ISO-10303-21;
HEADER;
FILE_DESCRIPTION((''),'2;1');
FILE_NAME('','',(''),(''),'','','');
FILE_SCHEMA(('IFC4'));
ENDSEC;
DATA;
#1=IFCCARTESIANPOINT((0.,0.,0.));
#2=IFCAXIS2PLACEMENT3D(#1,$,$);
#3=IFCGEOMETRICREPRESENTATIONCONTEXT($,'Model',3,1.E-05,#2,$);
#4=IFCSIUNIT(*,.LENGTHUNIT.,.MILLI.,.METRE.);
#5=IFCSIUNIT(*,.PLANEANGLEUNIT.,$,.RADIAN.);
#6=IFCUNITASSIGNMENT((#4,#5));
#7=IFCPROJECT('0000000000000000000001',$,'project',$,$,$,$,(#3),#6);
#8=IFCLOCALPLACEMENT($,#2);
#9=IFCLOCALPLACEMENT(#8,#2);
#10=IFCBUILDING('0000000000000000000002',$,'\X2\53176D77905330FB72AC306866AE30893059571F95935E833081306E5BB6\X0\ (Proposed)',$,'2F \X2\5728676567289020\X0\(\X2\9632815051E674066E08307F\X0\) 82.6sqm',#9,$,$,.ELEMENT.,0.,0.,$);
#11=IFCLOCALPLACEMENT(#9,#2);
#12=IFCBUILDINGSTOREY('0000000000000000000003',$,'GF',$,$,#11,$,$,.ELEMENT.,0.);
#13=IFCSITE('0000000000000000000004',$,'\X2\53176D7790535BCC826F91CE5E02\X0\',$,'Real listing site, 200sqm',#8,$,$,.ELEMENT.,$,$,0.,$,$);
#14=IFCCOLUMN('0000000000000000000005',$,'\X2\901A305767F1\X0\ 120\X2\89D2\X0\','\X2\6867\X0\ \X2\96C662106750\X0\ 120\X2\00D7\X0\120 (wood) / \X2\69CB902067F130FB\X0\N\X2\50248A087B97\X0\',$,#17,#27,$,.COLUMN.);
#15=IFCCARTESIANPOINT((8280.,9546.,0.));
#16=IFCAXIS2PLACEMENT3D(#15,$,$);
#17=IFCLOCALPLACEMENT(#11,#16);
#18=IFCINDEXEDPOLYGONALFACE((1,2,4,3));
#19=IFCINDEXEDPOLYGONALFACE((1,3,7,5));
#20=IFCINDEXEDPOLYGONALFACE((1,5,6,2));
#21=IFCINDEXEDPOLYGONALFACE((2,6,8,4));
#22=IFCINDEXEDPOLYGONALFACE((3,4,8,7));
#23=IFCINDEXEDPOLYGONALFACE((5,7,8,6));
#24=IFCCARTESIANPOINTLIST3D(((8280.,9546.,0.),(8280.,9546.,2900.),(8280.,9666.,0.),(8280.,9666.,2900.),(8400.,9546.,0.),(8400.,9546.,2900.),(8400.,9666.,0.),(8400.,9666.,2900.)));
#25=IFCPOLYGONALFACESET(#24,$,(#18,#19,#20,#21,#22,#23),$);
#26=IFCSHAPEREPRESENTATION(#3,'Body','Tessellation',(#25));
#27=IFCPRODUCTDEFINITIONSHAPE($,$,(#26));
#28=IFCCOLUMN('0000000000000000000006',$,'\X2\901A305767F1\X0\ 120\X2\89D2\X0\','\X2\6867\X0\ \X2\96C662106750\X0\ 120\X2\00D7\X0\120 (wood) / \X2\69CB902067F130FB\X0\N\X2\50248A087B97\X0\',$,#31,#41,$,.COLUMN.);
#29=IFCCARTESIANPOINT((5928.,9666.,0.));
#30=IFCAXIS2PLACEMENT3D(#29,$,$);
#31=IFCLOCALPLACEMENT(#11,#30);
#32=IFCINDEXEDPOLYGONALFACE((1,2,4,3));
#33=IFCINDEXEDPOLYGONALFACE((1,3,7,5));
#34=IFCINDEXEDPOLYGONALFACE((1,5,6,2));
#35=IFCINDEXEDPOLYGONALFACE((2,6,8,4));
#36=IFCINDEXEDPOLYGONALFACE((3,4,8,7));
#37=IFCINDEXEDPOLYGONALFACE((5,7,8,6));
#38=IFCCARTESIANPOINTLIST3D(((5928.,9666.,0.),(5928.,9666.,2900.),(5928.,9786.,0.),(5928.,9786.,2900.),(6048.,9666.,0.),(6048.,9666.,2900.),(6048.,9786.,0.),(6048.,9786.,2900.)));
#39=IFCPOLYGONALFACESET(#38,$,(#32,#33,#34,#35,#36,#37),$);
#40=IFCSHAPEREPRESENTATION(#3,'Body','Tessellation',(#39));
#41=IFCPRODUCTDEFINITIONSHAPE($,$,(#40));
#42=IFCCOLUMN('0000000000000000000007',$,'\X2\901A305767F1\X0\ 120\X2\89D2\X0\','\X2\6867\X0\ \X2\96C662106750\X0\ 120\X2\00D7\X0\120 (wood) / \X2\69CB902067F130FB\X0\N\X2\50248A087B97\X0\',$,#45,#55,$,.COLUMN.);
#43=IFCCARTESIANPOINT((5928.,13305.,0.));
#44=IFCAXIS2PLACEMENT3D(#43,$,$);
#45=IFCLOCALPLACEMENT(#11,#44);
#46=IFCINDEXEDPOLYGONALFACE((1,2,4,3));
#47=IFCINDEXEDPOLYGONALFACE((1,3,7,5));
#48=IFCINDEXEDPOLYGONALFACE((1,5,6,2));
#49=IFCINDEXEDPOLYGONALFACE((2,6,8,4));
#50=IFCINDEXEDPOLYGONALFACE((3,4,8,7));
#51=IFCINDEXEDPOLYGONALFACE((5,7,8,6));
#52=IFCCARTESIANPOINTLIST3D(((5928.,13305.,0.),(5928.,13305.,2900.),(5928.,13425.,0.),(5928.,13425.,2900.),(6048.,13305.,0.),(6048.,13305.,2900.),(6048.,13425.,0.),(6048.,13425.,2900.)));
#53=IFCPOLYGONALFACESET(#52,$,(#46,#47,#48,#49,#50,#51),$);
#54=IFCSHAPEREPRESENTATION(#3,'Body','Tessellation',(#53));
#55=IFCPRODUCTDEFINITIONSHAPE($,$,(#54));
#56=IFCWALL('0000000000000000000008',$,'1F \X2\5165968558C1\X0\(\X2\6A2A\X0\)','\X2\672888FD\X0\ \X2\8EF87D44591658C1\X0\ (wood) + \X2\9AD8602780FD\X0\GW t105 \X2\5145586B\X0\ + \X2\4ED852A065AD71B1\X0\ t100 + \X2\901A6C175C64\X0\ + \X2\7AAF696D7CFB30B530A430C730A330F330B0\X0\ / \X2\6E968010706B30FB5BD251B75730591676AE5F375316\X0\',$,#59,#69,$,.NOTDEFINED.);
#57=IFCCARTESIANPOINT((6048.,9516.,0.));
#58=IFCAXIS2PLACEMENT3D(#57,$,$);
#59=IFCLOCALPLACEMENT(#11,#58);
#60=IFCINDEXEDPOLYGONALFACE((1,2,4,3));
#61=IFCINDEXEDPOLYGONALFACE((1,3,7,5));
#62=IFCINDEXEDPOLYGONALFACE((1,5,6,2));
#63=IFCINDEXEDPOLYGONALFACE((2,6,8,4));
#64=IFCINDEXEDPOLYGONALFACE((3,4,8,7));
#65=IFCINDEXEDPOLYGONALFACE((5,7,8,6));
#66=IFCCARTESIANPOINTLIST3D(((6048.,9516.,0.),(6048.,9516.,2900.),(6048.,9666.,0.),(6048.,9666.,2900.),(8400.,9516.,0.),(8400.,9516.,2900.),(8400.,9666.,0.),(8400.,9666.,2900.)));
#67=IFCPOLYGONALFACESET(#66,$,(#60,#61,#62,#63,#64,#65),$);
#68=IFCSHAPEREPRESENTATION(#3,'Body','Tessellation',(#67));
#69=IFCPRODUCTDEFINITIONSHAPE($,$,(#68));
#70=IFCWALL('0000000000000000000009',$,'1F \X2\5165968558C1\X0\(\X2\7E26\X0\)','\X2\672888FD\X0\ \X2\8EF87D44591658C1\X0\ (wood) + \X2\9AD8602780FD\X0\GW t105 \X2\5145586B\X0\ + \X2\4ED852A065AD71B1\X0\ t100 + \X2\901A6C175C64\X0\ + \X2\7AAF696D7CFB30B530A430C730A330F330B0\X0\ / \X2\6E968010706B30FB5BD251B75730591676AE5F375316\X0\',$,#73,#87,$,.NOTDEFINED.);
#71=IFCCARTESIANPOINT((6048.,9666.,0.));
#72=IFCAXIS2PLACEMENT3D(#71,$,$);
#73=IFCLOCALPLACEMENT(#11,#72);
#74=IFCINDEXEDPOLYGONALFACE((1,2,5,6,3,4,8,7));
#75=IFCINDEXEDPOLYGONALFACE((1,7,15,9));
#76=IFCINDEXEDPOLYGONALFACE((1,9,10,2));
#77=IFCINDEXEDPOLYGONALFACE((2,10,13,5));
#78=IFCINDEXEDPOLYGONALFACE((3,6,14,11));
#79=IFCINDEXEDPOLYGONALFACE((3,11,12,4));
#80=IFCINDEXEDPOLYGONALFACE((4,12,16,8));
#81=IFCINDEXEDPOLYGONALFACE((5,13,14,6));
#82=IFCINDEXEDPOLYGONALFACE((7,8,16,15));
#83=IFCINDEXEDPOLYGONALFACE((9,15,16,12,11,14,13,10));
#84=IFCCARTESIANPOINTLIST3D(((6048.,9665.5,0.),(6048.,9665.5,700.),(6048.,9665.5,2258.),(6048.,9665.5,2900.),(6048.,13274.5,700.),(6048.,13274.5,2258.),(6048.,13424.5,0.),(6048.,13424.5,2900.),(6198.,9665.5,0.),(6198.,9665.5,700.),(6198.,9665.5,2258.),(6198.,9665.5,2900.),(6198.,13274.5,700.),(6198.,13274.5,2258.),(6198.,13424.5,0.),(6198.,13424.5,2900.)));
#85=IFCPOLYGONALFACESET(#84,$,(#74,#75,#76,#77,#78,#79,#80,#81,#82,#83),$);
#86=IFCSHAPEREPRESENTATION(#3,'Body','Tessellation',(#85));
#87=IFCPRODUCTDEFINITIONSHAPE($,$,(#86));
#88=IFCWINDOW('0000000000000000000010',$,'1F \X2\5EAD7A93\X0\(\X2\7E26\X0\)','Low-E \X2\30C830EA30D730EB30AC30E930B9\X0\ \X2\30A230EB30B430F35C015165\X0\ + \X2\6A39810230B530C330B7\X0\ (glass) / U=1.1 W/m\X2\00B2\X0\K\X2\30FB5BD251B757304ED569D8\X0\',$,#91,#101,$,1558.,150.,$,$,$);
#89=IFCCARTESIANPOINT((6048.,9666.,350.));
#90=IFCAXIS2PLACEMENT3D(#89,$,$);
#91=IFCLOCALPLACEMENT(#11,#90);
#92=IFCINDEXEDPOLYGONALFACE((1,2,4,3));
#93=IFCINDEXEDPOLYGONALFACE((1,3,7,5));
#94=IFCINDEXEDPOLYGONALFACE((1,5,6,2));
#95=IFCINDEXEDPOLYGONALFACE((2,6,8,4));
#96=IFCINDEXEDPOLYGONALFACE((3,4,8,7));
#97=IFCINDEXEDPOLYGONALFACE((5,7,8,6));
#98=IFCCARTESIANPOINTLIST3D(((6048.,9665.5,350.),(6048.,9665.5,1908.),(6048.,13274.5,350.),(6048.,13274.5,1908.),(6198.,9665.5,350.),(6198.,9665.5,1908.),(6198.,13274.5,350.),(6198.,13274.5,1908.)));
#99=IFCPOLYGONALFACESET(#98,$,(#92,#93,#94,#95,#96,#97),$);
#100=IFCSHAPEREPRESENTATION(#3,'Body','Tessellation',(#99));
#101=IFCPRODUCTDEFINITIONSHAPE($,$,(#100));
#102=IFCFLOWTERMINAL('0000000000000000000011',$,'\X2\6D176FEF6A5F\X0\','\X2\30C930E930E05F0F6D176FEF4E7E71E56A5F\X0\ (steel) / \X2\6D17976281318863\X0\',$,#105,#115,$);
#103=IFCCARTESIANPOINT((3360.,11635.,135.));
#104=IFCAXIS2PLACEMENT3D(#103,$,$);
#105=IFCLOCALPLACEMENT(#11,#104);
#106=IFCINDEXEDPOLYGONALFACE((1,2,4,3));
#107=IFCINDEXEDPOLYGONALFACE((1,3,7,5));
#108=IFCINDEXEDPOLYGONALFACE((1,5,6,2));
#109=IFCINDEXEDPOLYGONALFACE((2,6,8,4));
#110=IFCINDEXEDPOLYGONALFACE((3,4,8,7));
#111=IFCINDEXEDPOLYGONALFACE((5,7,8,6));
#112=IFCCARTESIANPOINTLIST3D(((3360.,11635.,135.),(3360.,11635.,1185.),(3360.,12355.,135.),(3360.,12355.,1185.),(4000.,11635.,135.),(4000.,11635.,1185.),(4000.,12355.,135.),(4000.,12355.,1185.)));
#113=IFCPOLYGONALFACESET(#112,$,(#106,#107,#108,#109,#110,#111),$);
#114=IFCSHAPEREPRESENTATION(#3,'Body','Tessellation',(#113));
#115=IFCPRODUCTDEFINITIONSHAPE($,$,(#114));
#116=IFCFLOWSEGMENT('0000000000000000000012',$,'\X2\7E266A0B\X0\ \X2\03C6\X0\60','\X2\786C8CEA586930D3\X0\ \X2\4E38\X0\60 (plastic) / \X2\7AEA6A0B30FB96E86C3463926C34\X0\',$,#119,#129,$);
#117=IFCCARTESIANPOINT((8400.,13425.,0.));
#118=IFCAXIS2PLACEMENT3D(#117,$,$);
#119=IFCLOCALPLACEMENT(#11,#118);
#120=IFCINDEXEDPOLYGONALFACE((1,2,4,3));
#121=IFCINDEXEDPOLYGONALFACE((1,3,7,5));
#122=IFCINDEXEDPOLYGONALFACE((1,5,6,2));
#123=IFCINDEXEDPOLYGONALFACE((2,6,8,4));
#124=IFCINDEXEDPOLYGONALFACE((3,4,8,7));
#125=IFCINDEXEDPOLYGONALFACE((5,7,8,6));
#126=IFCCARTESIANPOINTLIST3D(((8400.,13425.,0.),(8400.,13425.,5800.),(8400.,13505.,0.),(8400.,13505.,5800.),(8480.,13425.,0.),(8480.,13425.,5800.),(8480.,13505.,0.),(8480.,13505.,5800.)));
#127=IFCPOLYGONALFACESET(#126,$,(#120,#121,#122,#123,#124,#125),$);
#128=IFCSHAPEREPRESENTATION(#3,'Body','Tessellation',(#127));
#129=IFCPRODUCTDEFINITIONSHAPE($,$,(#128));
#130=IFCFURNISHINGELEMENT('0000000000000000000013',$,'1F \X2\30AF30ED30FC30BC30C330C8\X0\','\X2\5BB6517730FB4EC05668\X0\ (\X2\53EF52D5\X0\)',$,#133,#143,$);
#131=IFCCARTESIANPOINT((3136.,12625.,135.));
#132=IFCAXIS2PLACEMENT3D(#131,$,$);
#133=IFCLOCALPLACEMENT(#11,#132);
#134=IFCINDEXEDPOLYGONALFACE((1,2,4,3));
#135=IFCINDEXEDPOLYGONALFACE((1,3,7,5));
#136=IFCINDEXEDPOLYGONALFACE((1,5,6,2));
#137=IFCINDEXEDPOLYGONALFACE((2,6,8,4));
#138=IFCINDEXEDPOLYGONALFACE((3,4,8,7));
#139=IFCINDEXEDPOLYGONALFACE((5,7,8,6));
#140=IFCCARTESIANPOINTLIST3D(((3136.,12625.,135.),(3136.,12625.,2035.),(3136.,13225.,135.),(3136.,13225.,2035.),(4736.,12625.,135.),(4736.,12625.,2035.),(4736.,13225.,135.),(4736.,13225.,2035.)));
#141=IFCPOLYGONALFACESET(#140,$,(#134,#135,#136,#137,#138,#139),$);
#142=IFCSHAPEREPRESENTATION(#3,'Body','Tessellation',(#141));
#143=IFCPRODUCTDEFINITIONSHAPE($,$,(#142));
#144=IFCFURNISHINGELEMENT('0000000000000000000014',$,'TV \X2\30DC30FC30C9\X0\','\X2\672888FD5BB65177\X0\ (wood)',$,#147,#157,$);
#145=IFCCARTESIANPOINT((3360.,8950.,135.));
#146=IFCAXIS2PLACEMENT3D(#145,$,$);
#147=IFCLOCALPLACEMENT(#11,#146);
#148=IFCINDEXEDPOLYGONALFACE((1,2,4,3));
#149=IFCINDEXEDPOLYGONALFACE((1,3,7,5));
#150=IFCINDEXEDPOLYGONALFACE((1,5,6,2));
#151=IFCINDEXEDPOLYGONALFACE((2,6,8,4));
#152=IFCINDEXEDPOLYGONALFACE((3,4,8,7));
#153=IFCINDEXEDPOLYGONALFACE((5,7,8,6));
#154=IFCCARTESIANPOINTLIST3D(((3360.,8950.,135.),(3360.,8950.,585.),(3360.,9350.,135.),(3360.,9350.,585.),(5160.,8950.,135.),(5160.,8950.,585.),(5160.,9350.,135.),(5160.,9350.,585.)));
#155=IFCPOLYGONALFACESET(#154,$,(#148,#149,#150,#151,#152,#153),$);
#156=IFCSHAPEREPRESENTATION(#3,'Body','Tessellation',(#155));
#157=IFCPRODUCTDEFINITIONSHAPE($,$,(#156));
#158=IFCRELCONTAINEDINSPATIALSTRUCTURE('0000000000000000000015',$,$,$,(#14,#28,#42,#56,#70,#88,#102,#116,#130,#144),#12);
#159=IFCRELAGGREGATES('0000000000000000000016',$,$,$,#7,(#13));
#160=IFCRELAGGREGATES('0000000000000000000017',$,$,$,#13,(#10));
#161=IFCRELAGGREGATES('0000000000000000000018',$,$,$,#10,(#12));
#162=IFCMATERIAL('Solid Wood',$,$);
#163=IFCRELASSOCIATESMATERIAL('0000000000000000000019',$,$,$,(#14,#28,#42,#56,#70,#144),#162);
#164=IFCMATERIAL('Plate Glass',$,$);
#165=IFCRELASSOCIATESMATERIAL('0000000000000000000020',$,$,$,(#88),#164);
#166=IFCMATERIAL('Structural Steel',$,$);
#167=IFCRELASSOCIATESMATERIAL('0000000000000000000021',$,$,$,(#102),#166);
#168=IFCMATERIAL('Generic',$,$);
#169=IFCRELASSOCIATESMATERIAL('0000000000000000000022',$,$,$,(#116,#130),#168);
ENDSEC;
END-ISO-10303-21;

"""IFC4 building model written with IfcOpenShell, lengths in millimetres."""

from ifc_helpers import new_model, si_unit, frame, frame_2d, origin, place, context, project, spatial, rectangle, extrude, material, element, fill, save


model = new_model("IFC4")

# Units and contexts
model_context = context("Model", 3, precision=1e-05, world=origin())
ifc_project = project(units=[si_unit("LENGTHUNIT", "METRE", prefix="MILLI"), si_unit("PLANEANGLEUNIT", "RADIAN")], contexts=[model_context])

# Site, building, storey
site_placement = place(None, origin())
site = spatial("IfcSite", under=ifc_project, at=site_placement, Name="北海道富良野市", ObjectType="Real listing site, 200sqm", CompositionType="ELEMENT", RefElevation=0.0)
building_placement = place(site_placement, origin())
building = spatial("IfcBuilding", under=site, at=building_placement, Name="北海道・犬と暮らす土間広めの家 (Proposed)", ObjectType="2F 在来木造(防腐処理済み) 82.6sqm", CompositionType="ELEMENT", ElevationOfRefHeight=0.0, ElevationOfTerrain=0.0)
storey_placement = place(building_placement, origin())
storey = spatial("IfcBuildingStorey", under=building, at=storey_placement, Name="GF", CompositionType="ELEMENT", Elevation=0.0)

# Columns
ifc_material_1 = material(Name="Solid Wood")
column_1_placement = place(storey_placement, frame((8280.0, 9546.0, 0.0)))
element("IfcColumn", 1, at=column_1_placement, inside=storey, material=ifc_material_1, Name="通し柱 120角", Description="桧 集成材 120×120 (wood) / 構造柱・N値計算", PredefinedType="COLUMN", context=model_context, shape_type="SweptSolid", body=[
    extrude(rectangle(XDim=120.0, YDim=120.0, at=frame_2d((60.0, 60.0))), frame((8280.0, 9546.0, 0.0)), (0.0, 0.0, 1.0), 2900.0),
])
column_2_placement = place(storey_placement, frame((5928.0, 9666.0, 0.0)))
element("IfcColumn", 2, at=column_2_placement, inside=storey, material=ifc_material_1, Name="通し柱 120角", Description="桧 集成材 120×120 (wood) / 構造柱・N値計算", PredefinedType="COLUMN", context=model_context, shape_type="SweptSolid", body=[
    extrude(rectangle(XDim=120.0, YDim=120.0, at=frame_2d((60.0, 60.0))), frame((5928.0, 9666.0, 0.0)), (0.0, 0.0, 1.0), 2900.0),
])
column_3_placement = place(storey_placement, frame((5928.0, 13305.0, 0.0)))
element("IfcColumn", 3, at=column_3_placement, inside=storey, material=ifc_material_1, Name="通し柱 120角", Description="桧 集成材 120×120 (wood) / 構造柱・N値計算", PredefinedType="COLUMN", context=model_context, shape_type="SweptSolid", body=[
    extrude(rectangle(XDim=120.0, YDim=120.0, at=frame_2d((60.0, 60.0))), frame((5928.0, 13305.0, 0.0)), (0.0, 0.0, 1.0), 2900.0),
])

# Wall
wall_1_placement = place(storey_placement, frame((6048.0, 9516.0, 0.0)))
element("IfcWall", 4, at=wall_1_placement, inside=storey, material=ifc_material_1, Name="1F 入隅壁(横)", Description="木製 軸組外壁 (wood) + 高性能GW t105 充填 + 付加断熱 t100 + 通気層 + 窯業系サイディング / 準耐火・寒冷地外皮強化", PredefinedType="NOTDEFINED", context=model_context, shape_type="SweptSolid", body=[
    extrude(rectangle(XDim=2352.0, YDim=150.0, at=frame_2d((1176.0, 75.0))), frame((6048.0, 9516.0, 0.0)), (0.0, 0.0, 1.0), 2900.0),
])

# Wall, opening, window
wall_2_placement = place(storey_placement, frame((6048.0, 9666.0, 0.0)))
wall_2 = element("IfcWall", 5, at=wall_2_placement, inside=storey, material=ifc_material_1, Name="1F 入隅壁(縦)", Description="木製 軸組外壁 (wood) + 高性能GW t105 充填 + 付加断熱 t100 + 通気層 + 窯業系サイディング / 準耐火・寒冷地外皮強化", PredefinedType="NOTDEFINED", context=model_context, shape_type="SweptSolid", body=[
    extrude(rectangle(XDim=150.0, YDim=3759.0, at=frame_2d((75.0, 1879.0))), frame((6048.0, 9666.0, 0.0)), (0.0, 0.0, 1.0), 2900.0),
])
opening_placement = place(storey_placement, frame((6048.0, 9666.0, 350.0)))
opening = element("IfcOpeningElement", 6, at=opening_placement, cuts=wall_2, PredefinedType="NOTDEFINED", context=model_context, shape_type="SweptSolid", body=[
    extrude(rectangle(XDim=150.0, YDim=3609.0, at=frame_2d((75.0, 1804.0))), frame((6048.0, 9666.0, 350.0)), (0.0, 0.0, 1.0), 1558.0),
])
ifc_material_2 = material(Name="Plate Glass")
window_placement = place(storey_placement, frame((6048.0, 9666.0, 350.0)))
window = element("IfcWindow", 7, at=window_placement, inside=storey, material=ifc_material_2, Name="1F 庭窓(縦)", Description="Low-E トリプルガラス アルゴン封入 + 樹脂サッシ (glass) / U=1.1 W/m²K・寒冷地仕様", OverallHeight=1558.0, OverallWidth=150.0, context=model_context, shape_type="SweptSolid", body=[
    extrude(rectangle(XDim=150.0, YDim=3609.0, at=frame_2d((75.0, 1804.0))), frame((6048.0, 9666.0, 350.0)), (0.0, 0.0, 1.0), 1558.0),
])
fill(opening, window)

# Flow terminal
ifc_material_3 = material(Name="Structural Steel")
flow_terminal_placement = place(storey_placement, frame((3360.0, 11635.0, 135.0)))
element("IfcFlowTerminal", 8, at=flow_terminal_placement, inside=storey, material=ifc_material_3, Name="洗濯機", Description="ドラム式洗濯乾燥機 (steel) / 洗面脱衣", context=model_context, shape_type="SweptSolid", body=[
    extrude(rectangle(XDim=640.0, YDim=720.0, at=frame_2d((320.0, 360.0))), frame((3360.0, 11635.0, 135.0)), (0.0, 0.0, 1.0), 1050.0),
])

# Flow segment
ifc_material_4 = material(Name="Generic")
flow_segment_placement = place(storey_placement, frame((8400.0, 13425.0, 0.0)))
element("IfcFlowSegment", 9, at=flow_segment_placement, inside=storey, material=ifc_material_4, Name="縦樋 φ60", Description="硬質塩ビ 丸60 (plastic) / 竪樋・雨水排水", context=model_context, shape_type="SweptSolid", body=[
    extrude(rectangle(XDim=80.0, YDim=80.0, at=frame_2d((40.0, 40.0))), frame((8400.0, 13425.0, 0.0)), (0.0, 0.0, 1.0), 5800.0),
])

# Furnishing elements
furnishing_1_placement = place(storey_placement, frame((3136.0, 12625.0, 135.0)))
element("IfcFurnishingElement", 10, at=furnishing_1_placement, inside=storey, material=ifc_material_4, Name="1F クローゼット", Description="家具・什器 (可動)", context=model_context, shape_type="SweptSolid", body=[
    extrude(rectangle(XDim=1600.0, YDim=600.0, at=frame_2d((800.0, 300.0))), frame((3136.0, 12625.0, 135.0)), (0.0, 0.0, 1.0), 1900.0),
])
furnishing_2_placement = place(storey_placement, frame((3360.0, 8950.0, 135.0)))
element("IfcFurnishingElement", 11, at=furnishing_2_placement, inside=storey, material=ifc_material_1, Name="TV ボード", Description="木製家具 (wood)", context=model_context, shape_type="SweptSolid", body=[
    extrude(rectangle(XDim=1800.0, YDim=400.0, at=frame_2d((900.0, 200.0))), frame((3360.0, 8950.0, 135.0)), (0.0, 0.0, 1.0), 450.0),
])

save(model, "model.ifc")
